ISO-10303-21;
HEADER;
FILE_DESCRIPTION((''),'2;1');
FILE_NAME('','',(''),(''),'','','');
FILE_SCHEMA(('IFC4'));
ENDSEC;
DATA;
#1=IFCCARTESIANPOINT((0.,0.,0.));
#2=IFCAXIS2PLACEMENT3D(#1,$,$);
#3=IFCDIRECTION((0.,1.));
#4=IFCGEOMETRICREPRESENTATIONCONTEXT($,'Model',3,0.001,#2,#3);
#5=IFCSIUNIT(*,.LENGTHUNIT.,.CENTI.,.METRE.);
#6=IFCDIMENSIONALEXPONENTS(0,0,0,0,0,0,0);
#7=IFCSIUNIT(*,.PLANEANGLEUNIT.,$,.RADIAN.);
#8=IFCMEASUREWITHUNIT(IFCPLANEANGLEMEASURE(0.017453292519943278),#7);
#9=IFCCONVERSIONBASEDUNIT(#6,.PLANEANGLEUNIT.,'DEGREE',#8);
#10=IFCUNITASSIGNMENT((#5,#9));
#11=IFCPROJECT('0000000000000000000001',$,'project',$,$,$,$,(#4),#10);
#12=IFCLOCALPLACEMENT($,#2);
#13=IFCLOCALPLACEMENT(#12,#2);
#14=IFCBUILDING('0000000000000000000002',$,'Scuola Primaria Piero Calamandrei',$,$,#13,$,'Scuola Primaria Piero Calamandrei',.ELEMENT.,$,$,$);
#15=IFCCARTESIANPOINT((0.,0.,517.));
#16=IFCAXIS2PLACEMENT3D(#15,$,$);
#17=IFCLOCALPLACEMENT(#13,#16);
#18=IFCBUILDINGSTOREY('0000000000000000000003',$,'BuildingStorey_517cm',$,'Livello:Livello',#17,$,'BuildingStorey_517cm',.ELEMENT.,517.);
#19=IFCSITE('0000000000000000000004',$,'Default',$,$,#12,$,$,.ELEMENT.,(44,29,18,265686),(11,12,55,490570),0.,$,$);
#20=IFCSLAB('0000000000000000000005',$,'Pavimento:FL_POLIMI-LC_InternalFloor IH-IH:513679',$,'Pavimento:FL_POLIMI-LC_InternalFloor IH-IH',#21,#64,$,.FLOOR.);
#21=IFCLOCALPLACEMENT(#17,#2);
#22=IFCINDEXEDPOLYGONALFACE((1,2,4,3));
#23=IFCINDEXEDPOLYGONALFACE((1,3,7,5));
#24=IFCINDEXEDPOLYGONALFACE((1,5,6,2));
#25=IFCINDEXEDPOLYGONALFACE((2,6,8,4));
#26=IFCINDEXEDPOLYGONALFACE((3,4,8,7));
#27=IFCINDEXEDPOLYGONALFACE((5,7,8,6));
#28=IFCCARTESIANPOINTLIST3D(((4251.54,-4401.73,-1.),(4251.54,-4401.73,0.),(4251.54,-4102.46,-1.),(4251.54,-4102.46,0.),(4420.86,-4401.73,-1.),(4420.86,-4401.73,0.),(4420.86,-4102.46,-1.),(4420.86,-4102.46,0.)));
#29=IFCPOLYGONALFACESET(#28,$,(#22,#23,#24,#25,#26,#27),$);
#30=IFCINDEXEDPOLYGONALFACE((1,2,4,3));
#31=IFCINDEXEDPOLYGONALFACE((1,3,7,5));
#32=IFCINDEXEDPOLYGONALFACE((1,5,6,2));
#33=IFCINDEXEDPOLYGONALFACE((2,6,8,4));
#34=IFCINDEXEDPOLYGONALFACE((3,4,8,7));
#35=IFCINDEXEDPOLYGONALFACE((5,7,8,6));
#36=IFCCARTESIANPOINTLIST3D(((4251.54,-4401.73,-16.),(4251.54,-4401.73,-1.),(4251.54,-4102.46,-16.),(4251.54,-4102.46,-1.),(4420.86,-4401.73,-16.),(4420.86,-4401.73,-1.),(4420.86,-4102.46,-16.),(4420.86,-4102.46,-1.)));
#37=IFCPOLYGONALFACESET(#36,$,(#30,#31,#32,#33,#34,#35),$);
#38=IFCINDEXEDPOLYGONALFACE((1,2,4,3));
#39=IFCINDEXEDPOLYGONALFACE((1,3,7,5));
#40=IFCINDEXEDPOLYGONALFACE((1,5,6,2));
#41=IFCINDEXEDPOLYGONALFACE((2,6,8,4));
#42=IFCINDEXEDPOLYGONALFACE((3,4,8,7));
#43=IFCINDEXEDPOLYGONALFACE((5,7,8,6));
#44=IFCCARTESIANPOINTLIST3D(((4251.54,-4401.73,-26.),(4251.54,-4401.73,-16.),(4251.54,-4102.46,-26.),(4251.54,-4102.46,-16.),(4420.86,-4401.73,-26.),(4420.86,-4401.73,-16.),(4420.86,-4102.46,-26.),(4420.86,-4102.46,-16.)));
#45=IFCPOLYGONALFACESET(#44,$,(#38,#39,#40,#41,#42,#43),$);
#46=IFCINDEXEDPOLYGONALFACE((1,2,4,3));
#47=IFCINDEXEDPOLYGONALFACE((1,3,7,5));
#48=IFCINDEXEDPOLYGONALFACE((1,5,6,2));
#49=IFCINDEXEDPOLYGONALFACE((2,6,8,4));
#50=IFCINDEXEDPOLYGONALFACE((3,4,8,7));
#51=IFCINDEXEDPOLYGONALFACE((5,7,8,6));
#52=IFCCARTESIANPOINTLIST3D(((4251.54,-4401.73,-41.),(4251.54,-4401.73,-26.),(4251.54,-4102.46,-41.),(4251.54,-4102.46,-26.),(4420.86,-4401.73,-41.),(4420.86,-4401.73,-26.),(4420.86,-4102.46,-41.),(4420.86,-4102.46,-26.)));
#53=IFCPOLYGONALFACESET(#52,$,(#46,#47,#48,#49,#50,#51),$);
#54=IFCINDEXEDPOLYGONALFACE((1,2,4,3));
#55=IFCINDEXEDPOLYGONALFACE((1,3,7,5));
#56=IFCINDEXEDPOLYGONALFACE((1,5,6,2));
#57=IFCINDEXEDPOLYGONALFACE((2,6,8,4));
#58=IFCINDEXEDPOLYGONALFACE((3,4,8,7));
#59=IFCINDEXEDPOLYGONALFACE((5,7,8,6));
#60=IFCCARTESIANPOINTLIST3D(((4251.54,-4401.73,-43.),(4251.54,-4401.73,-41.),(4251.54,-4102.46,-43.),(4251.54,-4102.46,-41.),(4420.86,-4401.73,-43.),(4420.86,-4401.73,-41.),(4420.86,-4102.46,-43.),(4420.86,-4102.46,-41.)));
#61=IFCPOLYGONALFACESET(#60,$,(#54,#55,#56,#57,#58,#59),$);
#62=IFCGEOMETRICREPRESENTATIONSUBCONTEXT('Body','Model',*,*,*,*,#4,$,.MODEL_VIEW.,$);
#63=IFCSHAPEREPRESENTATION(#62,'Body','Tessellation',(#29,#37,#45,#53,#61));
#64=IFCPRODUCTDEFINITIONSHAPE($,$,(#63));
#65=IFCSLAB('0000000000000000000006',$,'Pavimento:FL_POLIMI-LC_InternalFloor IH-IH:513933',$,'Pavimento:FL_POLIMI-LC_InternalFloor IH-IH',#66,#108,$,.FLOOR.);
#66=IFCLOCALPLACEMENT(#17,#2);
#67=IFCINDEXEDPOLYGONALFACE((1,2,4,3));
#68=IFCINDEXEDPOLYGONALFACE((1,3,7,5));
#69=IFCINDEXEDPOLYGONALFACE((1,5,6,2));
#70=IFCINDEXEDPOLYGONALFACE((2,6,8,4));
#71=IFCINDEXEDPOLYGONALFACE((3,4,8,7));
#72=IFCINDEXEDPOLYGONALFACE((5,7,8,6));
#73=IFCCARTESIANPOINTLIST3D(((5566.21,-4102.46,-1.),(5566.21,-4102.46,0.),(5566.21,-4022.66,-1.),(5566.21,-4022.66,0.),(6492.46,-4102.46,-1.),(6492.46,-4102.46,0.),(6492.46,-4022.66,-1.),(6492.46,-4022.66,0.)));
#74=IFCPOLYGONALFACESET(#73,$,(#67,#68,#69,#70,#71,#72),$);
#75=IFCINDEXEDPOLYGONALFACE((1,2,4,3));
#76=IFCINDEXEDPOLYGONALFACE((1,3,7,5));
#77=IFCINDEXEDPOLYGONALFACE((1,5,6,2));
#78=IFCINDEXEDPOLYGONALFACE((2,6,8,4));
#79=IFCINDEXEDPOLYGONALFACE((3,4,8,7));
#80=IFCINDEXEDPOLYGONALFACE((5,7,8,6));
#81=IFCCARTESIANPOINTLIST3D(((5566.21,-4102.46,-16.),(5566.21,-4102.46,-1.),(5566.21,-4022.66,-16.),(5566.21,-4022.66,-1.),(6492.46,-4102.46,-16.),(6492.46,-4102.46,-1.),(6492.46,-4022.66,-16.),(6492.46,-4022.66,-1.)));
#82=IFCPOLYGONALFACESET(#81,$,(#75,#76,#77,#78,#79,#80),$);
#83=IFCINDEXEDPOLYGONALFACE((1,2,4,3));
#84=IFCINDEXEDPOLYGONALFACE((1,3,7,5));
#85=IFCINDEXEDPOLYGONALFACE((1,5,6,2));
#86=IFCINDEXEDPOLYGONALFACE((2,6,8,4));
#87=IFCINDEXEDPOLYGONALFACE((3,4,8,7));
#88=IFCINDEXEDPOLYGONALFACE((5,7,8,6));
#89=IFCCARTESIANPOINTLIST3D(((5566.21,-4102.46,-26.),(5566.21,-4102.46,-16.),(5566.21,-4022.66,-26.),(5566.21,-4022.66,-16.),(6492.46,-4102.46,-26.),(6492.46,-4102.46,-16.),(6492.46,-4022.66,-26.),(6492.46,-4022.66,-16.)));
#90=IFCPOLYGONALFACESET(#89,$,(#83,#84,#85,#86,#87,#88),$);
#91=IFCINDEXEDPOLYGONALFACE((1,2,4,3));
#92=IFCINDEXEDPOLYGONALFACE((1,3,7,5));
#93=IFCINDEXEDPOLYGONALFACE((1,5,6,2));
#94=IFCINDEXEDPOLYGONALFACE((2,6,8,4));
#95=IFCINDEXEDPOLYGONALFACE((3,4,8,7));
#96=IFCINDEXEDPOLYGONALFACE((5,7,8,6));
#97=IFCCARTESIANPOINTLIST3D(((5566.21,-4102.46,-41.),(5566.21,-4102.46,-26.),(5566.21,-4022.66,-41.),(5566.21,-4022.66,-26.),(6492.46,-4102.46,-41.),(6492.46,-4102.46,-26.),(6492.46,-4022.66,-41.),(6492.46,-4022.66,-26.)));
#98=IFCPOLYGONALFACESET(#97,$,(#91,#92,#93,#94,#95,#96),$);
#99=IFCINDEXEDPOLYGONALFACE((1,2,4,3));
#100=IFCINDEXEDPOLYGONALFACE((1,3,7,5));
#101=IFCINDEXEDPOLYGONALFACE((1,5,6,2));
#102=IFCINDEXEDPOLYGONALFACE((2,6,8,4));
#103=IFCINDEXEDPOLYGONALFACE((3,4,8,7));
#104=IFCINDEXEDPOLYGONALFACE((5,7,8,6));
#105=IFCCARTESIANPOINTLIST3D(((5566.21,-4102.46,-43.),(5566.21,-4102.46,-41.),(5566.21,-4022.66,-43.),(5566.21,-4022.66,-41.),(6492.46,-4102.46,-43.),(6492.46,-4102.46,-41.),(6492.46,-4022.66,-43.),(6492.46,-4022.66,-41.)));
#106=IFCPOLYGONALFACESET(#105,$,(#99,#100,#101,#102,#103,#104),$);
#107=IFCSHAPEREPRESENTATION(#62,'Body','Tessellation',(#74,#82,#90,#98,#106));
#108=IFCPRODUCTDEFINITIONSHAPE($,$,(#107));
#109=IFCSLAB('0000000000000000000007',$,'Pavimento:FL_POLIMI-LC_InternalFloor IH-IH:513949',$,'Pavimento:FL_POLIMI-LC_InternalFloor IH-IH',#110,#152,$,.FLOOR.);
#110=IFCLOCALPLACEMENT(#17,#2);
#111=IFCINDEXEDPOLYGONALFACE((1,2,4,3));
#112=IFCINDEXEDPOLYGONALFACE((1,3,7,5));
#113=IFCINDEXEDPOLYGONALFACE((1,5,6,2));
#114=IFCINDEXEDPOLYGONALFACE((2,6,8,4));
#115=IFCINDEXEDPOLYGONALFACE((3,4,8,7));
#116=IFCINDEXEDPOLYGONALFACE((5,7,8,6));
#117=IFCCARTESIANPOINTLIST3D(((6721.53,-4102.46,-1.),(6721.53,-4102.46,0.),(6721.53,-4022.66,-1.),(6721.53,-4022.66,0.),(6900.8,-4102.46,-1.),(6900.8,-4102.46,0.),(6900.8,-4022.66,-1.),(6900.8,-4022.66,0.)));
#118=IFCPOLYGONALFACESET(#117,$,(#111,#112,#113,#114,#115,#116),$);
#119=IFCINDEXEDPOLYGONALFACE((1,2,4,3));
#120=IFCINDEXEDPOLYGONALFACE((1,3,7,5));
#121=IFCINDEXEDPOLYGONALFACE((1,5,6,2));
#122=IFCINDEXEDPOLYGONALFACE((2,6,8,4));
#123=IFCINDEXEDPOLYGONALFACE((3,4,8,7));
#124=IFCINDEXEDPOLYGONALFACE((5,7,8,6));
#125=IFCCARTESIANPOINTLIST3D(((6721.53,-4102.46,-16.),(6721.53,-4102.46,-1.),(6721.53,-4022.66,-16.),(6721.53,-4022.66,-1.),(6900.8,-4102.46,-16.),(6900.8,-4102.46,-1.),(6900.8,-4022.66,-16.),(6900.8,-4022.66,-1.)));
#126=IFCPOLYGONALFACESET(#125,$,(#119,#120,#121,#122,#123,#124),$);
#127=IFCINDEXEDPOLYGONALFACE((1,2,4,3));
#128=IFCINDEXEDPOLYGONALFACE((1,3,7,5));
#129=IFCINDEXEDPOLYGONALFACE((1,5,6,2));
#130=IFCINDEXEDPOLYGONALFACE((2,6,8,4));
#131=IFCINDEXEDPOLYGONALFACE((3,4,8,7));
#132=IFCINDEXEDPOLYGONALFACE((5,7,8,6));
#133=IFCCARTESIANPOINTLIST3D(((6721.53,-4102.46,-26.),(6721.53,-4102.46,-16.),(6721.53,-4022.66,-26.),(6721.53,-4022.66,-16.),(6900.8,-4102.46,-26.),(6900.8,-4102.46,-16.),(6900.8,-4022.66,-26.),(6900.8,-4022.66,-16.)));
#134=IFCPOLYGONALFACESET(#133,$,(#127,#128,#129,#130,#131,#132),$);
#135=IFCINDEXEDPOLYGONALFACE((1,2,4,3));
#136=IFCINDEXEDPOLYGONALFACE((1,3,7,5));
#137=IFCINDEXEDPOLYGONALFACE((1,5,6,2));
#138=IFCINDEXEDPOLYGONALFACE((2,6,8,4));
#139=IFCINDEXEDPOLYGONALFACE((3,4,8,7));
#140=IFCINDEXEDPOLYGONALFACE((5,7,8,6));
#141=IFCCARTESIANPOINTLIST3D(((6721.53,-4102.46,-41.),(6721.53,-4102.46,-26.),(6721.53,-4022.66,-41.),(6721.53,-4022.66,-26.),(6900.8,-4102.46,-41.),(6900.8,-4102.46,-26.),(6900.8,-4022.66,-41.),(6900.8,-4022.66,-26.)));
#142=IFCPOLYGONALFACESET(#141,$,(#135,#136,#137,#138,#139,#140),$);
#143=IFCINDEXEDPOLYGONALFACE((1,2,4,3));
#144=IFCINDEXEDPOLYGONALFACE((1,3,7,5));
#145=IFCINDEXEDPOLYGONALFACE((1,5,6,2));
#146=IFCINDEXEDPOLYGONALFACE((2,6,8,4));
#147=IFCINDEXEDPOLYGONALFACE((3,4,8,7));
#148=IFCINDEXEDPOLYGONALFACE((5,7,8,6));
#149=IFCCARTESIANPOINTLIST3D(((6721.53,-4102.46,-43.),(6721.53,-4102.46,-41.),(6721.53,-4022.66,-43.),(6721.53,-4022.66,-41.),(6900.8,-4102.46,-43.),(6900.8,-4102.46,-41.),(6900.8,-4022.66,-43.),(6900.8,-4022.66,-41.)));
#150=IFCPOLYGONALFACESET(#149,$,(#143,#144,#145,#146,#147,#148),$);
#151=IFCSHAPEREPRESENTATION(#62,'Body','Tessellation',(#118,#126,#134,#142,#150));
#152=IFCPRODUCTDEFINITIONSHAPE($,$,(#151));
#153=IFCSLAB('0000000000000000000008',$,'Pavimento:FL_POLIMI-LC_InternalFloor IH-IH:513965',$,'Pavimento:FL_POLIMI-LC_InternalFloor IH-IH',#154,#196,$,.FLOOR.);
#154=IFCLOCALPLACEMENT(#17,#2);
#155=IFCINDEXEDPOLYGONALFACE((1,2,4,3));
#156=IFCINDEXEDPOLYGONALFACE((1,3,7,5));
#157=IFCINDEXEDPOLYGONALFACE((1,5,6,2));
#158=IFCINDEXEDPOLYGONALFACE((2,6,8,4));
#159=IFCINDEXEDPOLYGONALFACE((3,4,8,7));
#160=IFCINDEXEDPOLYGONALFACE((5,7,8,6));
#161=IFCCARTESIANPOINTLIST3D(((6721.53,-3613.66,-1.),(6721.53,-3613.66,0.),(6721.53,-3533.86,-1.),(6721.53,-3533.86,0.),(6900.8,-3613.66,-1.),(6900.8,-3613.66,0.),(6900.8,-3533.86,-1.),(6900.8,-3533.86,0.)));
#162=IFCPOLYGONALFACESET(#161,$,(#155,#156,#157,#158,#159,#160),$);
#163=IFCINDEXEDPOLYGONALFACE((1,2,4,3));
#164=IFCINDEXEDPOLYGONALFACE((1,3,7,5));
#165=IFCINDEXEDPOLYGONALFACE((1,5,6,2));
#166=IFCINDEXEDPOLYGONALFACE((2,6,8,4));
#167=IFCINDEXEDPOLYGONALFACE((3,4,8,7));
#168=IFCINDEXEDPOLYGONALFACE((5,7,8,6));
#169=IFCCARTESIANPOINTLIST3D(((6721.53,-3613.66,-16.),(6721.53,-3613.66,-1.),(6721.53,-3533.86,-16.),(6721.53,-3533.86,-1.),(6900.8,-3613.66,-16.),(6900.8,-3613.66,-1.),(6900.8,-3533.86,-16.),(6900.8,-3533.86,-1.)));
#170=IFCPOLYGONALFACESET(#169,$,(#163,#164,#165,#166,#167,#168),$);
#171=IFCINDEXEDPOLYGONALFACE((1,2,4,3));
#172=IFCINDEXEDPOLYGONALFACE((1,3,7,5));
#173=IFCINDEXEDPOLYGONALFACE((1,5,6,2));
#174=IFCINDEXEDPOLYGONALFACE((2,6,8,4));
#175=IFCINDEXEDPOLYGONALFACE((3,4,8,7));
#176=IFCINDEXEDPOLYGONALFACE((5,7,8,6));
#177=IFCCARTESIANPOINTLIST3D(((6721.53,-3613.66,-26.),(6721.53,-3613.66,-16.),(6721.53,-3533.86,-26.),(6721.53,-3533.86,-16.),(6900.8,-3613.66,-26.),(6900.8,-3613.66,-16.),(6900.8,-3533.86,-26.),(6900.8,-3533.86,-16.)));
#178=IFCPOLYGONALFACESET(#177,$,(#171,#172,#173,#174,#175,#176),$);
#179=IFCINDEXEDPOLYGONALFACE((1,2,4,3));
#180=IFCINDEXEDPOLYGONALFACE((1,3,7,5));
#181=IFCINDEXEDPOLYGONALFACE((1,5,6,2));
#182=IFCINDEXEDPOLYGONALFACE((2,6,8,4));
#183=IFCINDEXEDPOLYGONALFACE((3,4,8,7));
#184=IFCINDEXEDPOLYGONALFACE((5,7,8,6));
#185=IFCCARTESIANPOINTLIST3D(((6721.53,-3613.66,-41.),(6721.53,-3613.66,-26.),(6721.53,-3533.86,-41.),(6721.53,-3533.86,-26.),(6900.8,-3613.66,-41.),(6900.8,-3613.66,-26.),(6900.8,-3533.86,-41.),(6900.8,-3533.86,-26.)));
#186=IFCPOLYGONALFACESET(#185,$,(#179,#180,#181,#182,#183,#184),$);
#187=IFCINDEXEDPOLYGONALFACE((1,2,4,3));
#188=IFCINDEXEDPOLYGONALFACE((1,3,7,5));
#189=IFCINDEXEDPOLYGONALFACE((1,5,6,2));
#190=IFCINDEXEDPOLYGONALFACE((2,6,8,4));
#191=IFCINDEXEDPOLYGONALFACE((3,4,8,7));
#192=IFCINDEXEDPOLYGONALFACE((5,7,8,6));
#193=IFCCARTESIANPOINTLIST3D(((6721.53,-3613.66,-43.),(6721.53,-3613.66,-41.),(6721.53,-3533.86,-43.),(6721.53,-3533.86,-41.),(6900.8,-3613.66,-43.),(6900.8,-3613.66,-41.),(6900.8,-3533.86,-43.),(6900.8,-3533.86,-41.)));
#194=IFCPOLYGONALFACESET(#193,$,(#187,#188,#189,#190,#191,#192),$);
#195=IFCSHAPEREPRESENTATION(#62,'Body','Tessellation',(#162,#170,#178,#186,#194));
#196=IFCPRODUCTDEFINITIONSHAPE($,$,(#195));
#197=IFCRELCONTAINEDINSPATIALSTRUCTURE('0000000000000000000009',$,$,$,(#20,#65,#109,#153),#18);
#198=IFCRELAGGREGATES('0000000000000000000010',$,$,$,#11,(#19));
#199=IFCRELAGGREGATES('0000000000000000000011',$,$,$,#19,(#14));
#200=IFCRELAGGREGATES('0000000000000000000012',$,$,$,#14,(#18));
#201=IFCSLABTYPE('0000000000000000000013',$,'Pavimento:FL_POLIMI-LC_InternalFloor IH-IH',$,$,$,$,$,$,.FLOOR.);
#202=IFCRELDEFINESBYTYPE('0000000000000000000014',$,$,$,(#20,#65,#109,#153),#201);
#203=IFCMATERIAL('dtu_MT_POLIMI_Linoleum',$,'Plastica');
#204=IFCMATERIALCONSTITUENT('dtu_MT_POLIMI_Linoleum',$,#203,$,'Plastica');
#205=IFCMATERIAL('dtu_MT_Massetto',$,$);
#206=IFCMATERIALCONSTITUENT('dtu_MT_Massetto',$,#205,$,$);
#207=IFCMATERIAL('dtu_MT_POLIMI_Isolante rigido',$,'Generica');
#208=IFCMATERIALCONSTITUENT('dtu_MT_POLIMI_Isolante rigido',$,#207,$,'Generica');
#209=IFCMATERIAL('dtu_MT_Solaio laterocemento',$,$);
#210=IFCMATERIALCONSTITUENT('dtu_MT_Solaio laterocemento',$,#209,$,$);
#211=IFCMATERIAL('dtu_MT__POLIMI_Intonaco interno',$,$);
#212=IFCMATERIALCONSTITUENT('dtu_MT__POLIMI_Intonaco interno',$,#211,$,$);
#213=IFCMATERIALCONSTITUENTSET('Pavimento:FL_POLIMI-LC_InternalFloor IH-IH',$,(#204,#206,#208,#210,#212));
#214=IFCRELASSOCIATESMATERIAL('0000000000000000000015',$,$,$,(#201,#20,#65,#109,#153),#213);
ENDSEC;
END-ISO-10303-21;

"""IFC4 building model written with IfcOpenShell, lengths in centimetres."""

from ifc_helpers import new_model, entity, si_unit, converted_unit, direction, frame, origin, place, context, subcontext, project, spatial, indexed_curve, outline, extrude, material, constituent, constituent_set, type_object, element, save


model = new_model("IFC4")

# Units and contexts
model_context = context("Model", 3, precision=0.001, world=origin(), true_north=direction((0.0, 1.0)))
body_context = subcontext(model_context, "Body", "Model", "MODEL_VIEW")
ifc_project = project(units=[si_unit("LENGTHUNIT", "METRE", prefix="CENTI"), converted_unit("PLANEANGLEUNIT", "DEGREE", entity("IfcPlaneAngleMeasure", 0.017453292519943278), si_unit("PLANEANGLEUNIT", "RADIAN"), dimensions=[0, 0, 0, 0, 0, 0, 0])], contexts=[model_context])

# Site, building, storey
site_placement = place(None, origin())
site = spatial("IfcSite", under=ifc_project, at=site_placement, Name="Default", CompositionType="ELEMENT", RefLatitude=(44, 29, 18, 265686), RefLongitude=(11, 12, 55, 490570), RefElevation=0.0)
building_placement = place(site_placement, origin())
building = spatial("IfcBuilding", under=site, at=building_placement, Name="Scuola Primaria Piero Calamandrei", LongName="Scuola Primaria Piero Calamandrei", CompositionType="ELEMENT")
storey_placement = place(building_placement, frame((0.0, 0.0, 517.0)))
storey = spatial("IfcBuildingStorey", under=building, at=storey_placement, Name="BuildingStorey_517cm", ObjectType="Livello:Livello", LongName="BuildingStorey_517cm", CompositionType="ELEMENT", Elevation=517.0)

# Slabs
ifc_material_1 = material(Name="dtu_MT_POLIMI_Linoleum", Category="Plastica")
ifc_constituent_1 = constituent(ifc_material_1, Name="dtu_MT_POLIMI_Linoleum", Category="Plastica")
ifc_material_2 = material(Name="dtu_MT_Massetto")
ifc_constituent_2 = constituent(ifc_material_2, Name="dtu_MT_Massetto")
ifc_material_3 = material(Name="dtu_MT_POLIMI_Isolante rigido", Category="Generica")
ifc_constituent_3 = constituent(ifc_material_3, Name="dtu_MT_POLIMI_Isolante rigido", Category="Generica")
ifc_material_4 = material(Name="dtu_MT_Solaio laterocemento")
ifc_constituent_4 = constituent(ifc_material_4, Name="dtu_MT_Solaio laterocemento")
ifc_material_5 = material(Name="dtu_MT__POLIMI_Intonaco interno")
ifc_constituent_5 = constituent(ifc_material_5, Name="dtu_MT__POLIMI_Intonaco interno")
ifc_constituent_set_1 = constituent_set(constituents=[ifc_constituent_1, ifc_constituent_2, ifc_constituent_3, ifc_constituent_4, ifc_constituent_5], Name="Pavimento:FL_POLIMI-LC_InternalFloor IH-IH")
slab_type_1 = type_object("IfcSlabType", Name="Pavimento:FL_POLIMI-LC_InternalFloor IH-IH", PredefinedType="FLOOR", material=ifc_constituent_set_1)
slab_1_placement = place(storey_placement, origin())
element("IfcSlab", 1, at=slab_1_placement, inside=storey, type_object=slab_type_1, material=ifc_constituent_set_1, Name="Pavimento:FL_POLIMI-LC_InternalFloor IH-IH:513679", ObjectType="Pavimento:FL_POLIMI-LC_InternalFloor IH-IH", PredefinedType="FLOOR", context=body_context, shape_type="SweptSolid", body=[
    extrude(outline(indexed_curve([(-84.66, -149.63), (84.66, -149.63), (84.66, 149.63), (-84.66, 149.63), (-84.66, -149.63)], self_intersect=False)), frame((4336.2, -4252.1, -1.0)), (0.0, 0.0, 1.0), 1.0),
    extrude(outline(indexed_curve([(-84.66, -149.63), (84.66, -149.63), (84.66, 149.63), (-84.66, 149.63), (-84.66, -149.63)], self_intersect=False)), frame((4336.2, -4252.1, -16.0)), (0.0, 0.0, 1.0), 15.0),
    extrude(outline(indexed_curve([(-84.66, -149.63), (84.66, -149.63), (84.66, 149.63), (-84.66, 149.63), (-84.66, -149.63)], self_intersect=False)), frame((4336.2, -4252.1, -26.0)), (0.0, 0.0, 1.0), 10.0),
    extrude(outline(indexed_curve([(-84.66, -149.63), (84.66, -149.63), (84.66, 149.63), (-84.66, 149.63), (-84.66, -149.63)], self_intersect=False)), frame((4336.2, -4252.1, -41.0)), (0.0, 0.0, 1.0), 15.0),
    extrude(outline(indexed_curve([(-84.66, -149.63), (84.66, -149.63), (84.66, 149.63), (-84.66, 149.63), (-84.66, -149.63)], self_intersect=False)), frame((4336.2, -4252.1, -43.0)), (0.0, 0.0, 1.0), 2.0),
])
slab_2_placement = place(storey_placement, origin())
element("IfcSlab", 2, at=slab_2_placement, inside=storey, type_object=slab_type_1, material=ifc_constituent_set_1, Name="Pavimento:FL_POLIMI-LC_InternalFloor IH-IH:513933", ObjectType="Pavimento:FL_POLIMI-LC_InternalFloor IH-IH", PredefinedType="FLOOR", context=body_context, shape_type="SweptSolid", body=[
    extrude(outline(indexed_curve([(-39.9, -463.12), (39.9, -463.12), (39.9, 463.12), (-39.9, 463.12), (-39.9, -463.12)], self_intersect=False)), frame((6029.33, -4062.56, -1.0), z_axis=(0.0, 0.0, 1.0), x_axis=(0.0, -1.0, 0.0)), (0.0, 0.0, 1.0), 1.0),
    extrude(outline(indexed_curve([(-39.9, -463.12), (39.9, -463.12), (39.9, 463.12), (-39.9, 463.12), (-39.9, -463.12)], self_intersect=False)), frame((6029.33, -4062.56, -16.0), z_axis=(0.0, 0.0, 1.0), x_axis=(0.0, -1.0, 0.0)), (0.0, 0.0, 1.0), 15.0),
    extrude(outline(indexed_curve([(-39.9, -463.12), (39.9, -463.12), (39.9, 463.12), (-39.9, 463.12), (-39.9, -463.12)], self_intersect=False)), frame((6029.33, -4062.56, -26.0), z_axis=(0.0, 0.0, 1.0), x_axis=(0.0, -1.0, 0.0)), (0.0, 0.0, 1.0), 10.0),
    extrude(outline(indexed_curve([(-39.9, -463.12), (39.9, -463.12), (39.9, 463.12), (-39.9, 463.12), (-39.9, -463.12)], self_intersect=False)), frame((6029.33, -4062.56, -41.0), z_axis=(0.0, 0.0, 1.0), x_axis=(0.0, -1.0, 0.0)), (0.0, 0.0, 1.0), 15.0),
    extrude(outline(indexed_curve([(-39.9, -463.12), (39.9, -463.12), (39.9, 463.12), (-39.9, 463.12), (-39.9, -463.12)], self_intersect=False)), frame((6029.33, -4062.56, -43.0), z_axis=(0.0, 0.0, 1.0), x_axis=(0.0, -1.0, 0.0)), (0.0, 0.0, 1.0), 2.0),
])
slab_3_placement = place(storey_placement, origin())
element("IfcSlab", 3, at=slab_3_placement, inside=storey, type_object=slab_type_1, material=ifc_constituent_set_1, Name="Pavimento:FL_POLIMI-LC_InternalFloor IH-IH:513949", ObjectType="Pavimento:FL_POLIMI-LC_InternalFloor IH-IH", PredefinedType="FLOOR", context=body_context, shape_type="SweptSolid", body=[
    extrude(outline(indexed_curve([(-39.9, -89.64), (39.9, -89.64), (39.9, 89.64), (-39.9, 89.64), (-39.9, -89.64)], self_intersect=False)), frame((6811.16, -4062.56, -1.0), z_axis=(0.0, 0.0, 1.0), x_axis=(0.0, -1.0, 0.0)), (0.0, 0.0, 1.0), 1.0),
    extrude(outline(indexed_curve([(-39.9, -89.64), (39.9, -89.64), (39.9, 89.64), (-39.9, 89.64), (-39.9, -89.64)], self_intersect=False)), frame((6811.16, -4062.56, -16.0), z_axis=(0.0, 0.0, 1.0), x_axis=(0.0, -1.0, 0.0)), (0.0, 0.0, 1.0), 15.0),
    extrude(outline(indexed_curve([(-39.9, -89.64), (39.9, -89.64), (39.9, 89.64), (-39.9, 89.64), (-39.9, -89.64)], self_intersect=False)), frame((6811.16, -4062.56, -26.0), z_axis=(0.0, 0.0, 1.0), x_axis=(0.0, -1.0, 0.0)), (0.0, 0.0, 1.0), 10.0),
    extrude(outline(indexed_curve([(-39.9, -89.64), (39.9, -89.64), (39.9, 89.64), (-39.9, 89.64), (-39.9, -89.64)], self_intersect=False)), frame((6811.16, -4062.56, -41.0), z_axis=(0.0, 0.0, 1.0), x_axis=(0.0, -1.0, 0.0)), (0.0, 0.0, 1.0), 15.0),
    extrude(outline(indexed_curve([(-39.9, -89.64), (39.9, -89.64), (39.9, 89.64), (-39.9, 89.64), (-39.9, -89.64)], self_intersect=False)), frame((6811.16, -4062.56, -43.0), z_axis=(0.0, 0.0, 1.0), x_axis=(0.0, -1.0, 0.0)), (0.0, 0.0, 1.0), 2.0),
])
slab_4_placement = place(storey_placement, origin())
element("IfcSlab", 4, at=slab_4_placement, inside=storey, type_object=slab_type_1, material=ifc_constituent_set_1, Name="Pavimento:FL_POLIMI-LC_InternalFloor IH-IH:513965", ObjectType="Pavimento:FL_POLIMI-LC_InternalFloor IH-IH", PredefinedType="FLOOR", context=body_context, shape_type="SweptSolid", body=[
    extrude(outline(indexed_curve([(-89.64, -39.9), (89.64, -39.9), (89.64, 39.9), (-89.64, 39.9), (-89.64, -39.9)], self_intersect=False)), frame((6811.16, -3573.76, -1.0)), (0.0, 0.0, 1.0), 1.0),
    extrude(outline(indexed_curve([(-89.64, -39.9), (89.64, -39.9), (89.64, 39.9), (-89.64, 39.9), (-89.64, -39.9)], self_intersect=False)), frame((6811.16, -3573.76, -16.0)), (0.0, 0.0, 1.0), 15.0),
    extrude(outline(indexed_curve([(-89.64, -39.9), (89.64, -39.9), (89.64, 39.9), (-89.64, 39.9), (-89.64, -39.9)], self_intersect=False)), frame((6811.16, -3573.76, -26.0)), (0.0, 0.0, 1.0), 10.0),
    extrude(outline(indexed_curve([(-89.64, -39.9), (89.64, -39.9), (89.64, 39.9), (-89.64, 39.9), (-89.64, -39.9)], self_intersect=False)), frame((6811.16, -3573.76, -41.0)), (0.0, 0.0, 1.0), 15.0),
    extrude(outline(indexed_curve([(-89.64, -39.9), (89.64, -39.9), (89.64, 39.9), (-89.64, 39.9), (-89.64, -39.9)], self_intersect=False)), frame((6811.16, -3573.76, -43.0)), (0.0, 0.0, 1.0), 2.0),
])

save(model, "model.ifc")
